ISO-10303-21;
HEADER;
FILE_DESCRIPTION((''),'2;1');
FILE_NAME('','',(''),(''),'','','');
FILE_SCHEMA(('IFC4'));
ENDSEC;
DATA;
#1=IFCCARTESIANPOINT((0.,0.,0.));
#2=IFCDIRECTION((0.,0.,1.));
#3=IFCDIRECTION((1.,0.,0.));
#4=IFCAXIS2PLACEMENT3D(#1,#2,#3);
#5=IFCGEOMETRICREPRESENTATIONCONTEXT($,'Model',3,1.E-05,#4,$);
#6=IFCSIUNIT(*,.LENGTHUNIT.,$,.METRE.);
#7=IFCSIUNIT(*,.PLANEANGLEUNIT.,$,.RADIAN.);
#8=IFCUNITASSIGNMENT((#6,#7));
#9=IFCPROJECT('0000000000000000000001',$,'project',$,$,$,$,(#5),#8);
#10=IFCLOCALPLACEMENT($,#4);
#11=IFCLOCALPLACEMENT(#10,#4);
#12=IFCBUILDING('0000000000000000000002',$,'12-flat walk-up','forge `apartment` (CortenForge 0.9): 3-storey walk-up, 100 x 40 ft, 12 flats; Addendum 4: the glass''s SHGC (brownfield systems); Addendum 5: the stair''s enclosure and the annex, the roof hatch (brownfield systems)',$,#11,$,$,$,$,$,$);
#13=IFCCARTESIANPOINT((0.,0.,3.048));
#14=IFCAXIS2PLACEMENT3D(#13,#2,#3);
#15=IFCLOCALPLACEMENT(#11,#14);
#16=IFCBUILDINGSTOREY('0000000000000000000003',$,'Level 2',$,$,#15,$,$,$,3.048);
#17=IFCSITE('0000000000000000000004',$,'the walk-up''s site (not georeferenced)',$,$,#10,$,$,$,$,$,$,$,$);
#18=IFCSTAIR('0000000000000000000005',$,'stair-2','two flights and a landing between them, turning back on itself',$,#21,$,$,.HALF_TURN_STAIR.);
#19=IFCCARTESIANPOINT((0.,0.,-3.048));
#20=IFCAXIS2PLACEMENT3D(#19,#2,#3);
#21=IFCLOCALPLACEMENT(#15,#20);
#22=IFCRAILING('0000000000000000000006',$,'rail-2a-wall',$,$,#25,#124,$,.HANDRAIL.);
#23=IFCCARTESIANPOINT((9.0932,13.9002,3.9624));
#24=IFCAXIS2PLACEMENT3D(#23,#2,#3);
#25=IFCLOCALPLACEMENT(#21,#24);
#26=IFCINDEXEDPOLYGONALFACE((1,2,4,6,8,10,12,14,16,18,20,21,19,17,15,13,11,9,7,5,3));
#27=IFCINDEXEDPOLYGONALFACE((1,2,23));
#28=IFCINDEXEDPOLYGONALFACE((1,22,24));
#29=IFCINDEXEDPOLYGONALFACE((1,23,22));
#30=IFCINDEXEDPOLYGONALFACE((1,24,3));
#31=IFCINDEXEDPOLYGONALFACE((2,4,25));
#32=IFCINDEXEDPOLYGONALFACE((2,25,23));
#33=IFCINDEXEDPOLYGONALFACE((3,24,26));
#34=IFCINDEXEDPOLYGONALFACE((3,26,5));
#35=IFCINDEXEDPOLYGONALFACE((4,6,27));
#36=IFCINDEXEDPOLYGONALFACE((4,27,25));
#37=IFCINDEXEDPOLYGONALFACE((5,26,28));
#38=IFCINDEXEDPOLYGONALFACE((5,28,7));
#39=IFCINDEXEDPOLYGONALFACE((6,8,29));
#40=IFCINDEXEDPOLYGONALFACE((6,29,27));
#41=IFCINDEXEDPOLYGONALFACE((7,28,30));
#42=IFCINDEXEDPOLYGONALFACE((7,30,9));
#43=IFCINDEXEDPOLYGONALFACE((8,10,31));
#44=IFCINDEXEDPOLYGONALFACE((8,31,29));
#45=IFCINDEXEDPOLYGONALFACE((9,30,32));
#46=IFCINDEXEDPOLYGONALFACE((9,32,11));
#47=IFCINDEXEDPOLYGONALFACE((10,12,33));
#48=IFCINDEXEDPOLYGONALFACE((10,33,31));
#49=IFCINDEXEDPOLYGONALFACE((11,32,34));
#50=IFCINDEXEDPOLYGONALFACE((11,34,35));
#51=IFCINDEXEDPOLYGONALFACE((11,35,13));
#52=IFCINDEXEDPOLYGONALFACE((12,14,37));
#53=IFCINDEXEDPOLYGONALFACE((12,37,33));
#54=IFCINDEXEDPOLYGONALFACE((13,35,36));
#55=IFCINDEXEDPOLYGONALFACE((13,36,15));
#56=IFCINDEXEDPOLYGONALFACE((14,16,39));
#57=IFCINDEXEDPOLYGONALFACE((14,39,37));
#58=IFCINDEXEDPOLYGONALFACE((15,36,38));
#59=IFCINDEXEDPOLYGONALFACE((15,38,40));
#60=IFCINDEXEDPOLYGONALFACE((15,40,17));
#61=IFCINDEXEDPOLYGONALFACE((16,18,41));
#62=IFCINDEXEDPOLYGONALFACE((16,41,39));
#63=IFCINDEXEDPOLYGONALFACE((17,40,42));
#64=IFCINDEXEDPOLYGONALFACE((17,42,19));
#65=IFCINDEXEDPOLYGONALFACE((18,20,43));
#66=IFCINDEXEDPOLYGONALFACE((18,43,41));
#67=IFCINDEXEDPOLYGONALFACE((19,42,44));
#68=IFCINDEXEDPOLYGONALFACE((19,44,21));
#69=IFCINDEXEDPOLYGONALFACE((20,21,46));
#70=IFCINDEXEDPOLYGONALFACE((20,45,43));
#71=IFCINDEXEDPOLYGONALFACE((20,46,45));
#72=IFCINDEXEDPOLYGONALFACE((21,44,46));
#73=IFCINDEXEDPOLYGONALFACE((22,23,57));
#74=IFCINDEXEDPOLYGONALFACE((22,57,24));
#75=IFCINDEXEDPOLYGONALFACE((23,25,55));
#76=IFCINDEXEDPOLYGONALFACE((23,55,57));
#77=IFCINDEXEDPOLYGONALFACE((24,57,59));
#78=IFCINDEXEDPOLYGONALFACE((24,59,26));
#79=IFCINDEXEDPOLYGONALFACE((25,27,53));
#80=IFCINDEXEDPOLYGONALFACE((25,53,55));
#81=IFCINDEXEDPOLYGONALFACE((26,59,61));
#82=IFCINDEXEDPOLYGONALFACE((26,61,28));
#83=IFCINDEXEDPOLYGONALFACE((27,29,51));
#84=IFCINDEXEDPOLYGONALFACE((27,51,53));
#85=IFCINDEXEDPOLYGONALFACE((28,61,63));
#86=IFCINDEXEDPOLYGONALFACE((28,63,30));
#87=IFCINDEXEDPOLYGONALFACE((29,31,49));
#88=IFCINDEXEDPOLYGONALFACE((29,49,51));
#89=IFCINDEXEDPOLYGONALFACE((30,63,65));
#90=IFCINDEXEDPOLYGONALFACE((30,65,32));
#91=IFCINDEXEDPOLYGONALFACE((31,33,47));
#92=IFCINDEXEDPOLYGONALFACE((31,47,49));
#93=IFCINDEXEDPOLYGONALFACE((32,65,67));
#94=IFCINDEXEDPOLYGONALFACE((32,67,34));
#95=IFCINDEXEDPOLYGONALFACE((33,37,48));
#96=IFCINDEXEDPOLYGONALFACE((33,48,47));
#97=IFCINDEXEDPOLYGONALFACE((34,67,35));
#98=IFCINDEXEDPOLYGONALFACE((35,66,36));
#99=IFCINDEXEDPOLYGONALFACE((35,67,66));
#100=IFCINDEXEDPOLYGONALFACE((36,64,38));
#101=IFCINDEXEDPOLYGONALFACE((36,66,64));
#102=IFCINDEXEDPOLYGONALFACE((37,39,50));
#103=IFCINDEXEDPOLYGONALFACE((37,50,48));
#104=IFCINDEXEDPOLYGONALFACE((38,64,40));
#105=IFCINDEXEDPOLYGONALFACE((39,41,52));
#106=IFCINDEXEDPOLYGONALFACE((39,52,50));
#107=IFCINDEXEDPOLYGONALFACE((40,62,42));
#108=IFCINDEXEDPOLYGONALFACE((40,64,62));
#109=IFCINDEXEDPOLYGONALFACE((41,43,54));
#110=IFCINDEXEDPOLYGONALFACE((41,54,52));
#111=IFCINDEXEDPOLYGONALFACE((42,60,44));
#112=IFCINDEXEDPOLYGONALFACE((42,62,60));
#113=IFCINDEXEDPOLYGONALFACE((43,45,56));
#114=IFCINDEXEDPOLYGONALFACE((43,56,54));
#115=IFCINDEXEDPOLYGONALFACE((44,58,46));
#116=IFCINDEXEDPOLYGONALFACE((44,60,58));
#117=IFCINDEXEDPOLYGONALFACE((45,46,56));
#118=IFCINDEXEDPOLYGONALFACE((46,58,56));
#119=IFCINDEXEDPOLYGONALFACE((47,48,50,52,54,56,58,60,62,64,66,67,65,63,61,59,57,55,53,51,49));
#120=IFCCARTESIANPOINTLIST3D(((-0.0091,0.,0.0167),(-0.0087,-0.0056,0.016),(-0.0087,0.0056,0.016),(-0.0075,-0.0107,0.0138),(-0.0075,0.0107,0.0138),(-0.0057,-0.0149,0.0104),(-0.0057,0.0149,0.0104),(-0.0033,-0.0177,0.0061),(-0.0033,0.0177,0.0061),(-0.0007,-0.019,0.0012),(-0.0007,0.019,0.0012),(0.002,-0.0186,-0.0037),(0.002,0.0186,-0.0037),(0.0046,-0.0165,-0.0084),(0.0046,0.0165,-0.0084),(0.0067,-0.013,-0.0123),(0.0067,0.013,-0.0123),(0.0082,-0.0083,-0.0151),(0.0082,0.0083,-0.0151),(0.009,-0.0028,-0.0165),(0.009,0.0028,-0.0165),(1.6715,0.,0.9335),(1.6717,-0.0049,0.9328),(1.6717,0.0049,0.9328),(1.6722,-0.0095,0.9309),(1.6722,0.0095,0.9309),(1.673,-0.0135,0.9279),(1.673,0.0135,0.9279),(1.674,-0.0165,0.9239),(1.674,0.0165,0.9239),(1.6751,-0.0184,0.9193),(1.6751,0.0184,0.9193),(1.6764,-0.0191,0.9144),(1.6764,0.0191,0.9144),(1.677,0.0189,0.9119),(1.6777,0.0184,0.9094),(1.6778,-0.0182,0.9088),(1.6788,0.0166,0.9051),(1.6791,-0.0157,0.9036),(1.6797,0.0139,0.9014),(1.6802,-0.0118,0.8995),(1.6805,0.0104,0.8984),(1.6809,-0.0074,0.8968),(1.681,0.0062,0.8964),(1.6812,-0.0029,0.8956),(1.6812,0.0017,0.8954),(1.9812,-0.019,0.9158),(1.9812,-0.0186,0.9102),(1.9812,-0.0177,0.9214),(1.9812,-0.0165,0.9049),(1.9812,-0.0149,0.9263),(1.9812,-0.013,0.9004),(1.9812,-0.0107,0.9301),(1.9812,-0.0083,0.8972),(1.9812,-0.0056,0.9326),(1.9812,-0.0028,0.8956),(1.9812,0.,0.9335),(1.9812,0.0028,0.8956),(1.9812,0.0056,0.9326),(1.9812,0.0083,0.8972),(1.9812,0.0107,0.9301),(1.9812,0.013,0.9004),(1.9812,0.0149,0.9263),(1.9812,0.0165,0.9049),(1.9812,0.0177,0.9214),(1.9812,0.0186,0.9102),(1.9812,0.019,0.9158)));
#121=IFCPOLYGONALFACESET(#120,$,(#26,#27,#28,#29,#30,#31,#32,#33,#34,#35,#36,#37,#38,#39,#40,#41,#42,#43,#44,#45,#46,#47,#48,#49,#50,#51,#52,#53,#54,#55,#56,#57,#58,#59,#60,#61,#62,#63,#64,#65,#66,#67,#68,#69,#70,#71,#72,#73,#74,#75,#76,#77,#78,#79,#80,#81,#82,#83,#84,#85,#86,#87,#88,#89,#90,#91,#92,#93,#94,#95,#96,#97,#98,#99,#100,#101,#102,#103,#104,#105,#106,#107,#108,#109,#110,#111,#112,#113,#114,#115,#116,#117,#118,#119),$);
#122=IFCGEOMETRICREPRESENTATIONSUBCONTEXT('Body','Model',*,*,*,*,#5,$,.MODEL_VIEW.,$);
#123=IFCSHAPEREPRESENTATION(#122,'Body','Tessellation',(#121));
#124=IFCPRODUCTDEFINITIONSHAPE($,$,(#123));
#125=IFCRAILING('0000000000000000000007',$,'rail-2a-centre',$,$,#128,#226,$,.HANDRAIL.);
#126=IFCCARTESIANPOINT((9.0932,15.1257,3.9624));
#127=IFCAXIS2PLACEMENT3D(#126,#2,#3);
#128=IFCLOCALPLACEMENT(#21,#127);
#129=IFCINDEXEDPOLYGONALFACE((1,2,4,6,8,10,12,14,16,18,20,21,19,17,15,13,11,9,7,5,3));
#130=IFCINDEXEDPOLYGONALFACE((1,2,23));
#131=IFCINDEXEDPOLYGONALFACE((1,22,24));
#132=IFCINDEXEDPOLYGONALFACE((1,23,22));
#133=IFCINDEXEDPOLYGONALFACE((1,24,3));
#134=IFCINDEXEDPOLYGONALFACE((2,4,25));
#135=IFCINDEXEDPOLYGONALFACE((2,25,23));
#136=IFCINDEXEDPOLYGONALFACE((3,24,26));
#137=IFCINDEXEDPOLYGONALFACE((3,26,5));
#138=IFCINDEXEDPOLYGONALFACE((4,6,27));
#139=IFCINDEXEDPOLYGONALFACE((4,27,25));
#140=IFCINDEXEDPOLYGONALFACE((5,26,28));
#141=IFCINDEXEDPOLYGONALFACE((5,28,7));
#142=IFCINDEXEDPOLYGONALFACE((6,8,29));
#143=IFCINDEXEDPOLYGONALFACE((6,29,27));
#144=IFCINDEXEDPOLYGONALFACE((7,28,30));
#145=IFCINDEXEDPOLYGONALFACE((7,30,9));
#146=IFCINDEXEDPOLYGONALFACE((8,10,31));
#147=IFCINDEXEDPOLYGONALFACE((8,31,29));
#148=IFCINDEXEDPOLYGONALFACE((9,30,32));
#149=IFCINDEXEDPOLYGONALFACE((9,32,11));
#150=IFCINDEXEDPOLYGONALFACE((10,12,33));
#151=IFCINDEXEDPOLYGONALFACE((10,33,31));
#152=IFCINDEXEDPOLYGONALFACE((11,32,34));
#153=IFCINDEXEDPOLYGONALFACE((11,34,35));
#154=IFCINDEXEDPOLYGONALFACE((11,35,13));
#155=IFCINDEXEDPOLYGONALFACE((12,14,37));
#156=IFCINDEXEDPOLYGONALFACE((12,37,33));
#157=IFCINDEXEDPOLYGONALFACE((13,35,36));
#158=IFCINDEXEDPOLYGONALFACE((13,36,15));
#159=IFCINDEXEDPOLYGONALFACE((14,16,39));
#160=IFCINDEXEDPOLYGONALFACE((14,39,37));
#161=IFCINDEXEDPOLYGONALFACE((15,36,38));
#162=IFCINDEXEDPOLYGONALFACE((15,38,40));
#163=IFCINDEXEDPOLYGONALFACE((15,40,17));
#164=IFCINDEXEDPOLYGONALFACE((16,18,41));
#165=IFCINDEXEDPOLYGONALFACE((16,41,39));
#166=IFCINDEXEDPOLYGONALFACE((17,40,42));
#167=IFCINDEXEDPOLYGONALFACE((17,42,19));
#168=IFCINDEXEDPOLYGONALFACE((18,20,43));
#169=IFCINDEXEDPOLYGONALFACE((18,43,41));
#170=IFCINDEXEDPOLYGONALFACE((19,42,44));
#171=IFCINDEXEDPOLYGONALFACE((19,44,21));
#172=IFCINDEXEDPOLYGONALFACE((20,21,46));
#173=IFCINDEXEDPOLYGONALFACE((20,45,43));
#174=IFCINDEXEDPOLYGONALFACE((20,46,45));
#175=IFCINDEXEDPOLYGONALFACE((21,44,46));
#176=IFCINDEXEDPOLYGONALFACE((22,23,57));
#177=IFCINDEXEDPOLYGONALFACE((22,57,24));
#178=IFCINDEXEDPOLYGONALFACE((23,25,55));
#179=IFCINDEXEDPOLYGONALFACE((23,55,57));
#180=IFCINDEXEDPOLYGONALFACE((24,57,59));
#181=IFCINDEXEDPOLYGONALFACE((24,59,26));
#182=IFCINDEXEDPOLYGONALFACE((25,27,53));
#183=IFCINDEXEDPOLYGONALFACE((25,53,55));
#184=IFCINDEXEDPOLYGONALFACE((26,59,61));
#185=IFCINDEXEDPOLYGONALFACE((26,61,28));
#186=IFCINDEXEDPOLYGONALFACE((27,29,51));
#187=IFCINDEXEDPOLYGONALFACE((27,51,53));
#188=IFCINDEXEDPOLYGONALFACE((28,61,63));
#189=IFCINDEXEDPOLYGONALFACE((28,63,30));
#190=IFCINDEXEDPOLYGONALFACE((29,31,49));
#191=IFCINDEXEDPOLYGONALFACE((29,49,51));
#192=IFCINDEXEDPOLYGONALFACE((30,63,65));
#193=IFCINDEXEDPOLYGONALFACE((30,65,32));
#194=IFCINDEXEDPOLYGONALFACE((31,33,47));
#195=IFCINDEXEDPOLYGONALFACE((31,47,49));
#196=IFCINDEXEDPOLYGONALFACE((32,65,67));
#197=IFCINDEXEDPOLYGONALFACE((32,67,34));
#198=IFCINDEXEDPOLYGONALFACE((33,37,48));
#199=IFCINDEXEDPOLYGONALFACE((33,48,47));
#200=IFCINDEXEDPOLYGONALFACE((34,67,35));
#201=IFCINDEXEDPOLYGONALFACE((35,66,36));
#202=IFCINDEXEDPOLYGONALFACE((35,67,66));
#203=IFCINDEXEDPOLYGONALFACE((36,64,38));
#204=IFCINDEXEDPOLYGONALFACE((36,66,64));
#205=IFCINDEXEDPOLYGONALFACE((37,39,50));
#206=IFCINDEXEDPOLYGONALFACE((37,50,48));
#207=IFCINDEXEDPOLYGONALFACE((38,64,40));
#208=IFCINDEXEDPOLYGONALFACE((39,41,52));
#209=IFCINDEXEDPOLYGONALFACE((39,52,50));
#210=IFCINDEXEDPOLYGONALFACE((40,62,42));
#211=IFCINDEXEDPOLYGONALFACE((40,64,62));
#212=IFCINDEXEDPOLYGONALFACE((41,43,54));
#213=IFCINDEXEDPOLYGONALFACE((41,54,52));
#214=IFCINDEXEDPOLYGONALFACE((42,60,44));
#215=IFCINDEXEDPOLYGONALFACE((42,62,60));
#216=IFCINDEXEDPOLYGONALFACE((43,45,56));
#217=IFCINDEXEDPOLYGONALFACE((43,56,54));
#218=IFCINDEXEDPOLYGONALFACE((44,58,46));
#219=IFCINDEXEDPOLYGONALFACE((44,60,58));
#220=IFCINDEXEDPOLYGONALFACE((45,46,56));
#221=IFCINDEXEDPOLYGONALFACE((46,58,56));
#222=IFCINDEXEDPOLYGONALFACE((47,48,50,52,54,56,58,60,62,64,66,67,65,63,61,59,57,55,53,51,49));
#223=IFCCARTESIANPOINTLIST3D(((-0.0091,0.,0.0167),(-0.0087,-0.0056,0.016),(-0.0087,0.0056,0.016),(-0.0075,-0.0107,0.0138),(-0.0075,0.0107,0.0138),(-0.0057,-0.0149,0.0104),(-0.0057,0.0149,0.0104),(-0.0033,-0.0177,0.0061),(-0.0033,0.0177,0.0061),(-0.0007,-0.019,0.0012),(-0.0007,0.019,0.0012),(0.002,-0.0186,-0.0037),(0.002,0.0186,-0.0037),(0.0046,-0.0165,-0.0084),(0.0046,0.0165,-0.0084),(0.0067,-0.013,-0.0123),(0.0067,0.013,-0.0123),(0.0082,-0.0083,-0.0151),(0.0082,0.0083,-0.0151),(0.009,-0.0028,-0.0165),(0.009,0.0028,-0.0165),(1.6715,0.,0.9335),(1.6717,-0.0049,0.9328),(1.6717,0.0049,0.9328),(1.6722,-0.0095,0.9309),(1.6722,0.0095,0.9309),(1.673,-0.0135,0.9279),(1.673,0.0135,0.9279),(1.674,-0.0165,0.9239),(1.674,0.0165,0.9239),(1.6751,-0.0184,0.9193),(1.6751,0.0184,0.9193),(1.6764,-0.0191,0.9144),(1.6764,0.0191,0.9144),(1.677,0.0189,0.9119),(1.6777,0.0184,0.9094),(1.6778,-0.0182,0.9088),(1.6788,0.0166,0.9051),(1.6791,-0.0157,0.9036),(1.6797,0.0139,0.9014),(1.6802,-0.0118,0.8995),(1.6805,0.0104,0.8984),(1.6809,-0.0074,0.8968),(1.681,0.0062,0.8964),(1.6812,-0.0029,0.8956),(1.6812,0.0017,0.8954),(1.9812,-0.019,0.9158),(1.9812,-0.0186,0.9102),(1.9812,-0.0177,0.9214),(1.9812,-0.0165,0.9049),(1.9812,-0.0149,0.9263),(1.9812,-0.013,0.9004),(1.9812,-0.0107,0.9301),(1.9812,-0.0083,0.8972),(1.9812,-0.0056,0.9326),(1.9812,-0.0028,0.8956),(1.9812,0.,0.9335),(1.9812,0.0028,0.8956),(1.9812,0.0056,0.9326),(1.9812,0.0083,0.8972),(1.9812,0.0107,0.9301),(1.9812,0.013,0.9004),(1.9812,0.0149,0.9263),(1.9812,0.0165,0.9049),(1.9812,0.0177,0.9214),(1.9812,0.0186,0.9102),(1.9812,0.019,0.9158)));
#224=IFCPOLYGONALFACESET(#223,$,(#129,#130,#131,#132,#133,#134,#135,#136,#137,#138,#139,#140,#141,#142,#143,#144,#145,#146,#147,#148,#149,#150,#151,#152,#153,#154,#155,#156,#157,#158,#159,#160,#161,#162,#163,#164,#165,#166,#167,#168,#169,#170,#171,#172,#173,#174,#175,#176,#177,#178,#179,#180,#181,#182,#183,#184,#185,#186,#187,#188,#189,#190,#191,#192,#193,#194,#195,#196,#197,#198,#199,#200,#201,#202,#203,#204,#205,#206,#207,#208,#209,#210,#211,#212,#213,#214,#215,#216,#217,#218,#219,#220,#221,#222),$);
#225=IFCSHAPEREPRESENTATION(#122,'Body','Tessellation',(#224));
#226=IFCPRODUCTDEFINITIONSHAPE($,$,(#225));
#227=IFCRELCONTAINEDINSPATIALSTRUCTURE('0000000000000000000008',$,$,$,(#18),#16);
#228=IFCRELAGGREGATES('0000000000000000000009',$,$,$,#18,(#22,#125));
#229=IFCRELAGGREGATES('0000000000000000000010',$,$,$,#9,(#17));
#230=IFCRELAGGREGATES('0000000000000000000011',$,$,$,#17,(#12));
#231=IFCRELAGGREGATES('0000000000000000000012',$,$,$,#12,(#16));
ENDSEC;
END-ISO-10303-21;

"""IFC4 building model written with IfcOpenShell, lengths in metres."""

from ifc_helpers import new_model, entity, si_unit, frame, origin_with_axes, place, context, subcontext, project, spatial, element, aggregate, save


model = new_model("IFC4")

# Units and contexts
model_context = context("Model", 3, precision=1e-05, world=origin_with_axes())
body_context = subcontext(model_context, "Body", "Model", "MODEL_VIEW")
ifc_project = project(units=[si_unit("LENGTHUNIT", "METRE"), si_unit("PLANEANGLEUNIT", "RADIAN")], contexts=[model_context])

# Site, building, storey
site_placement = place(None, origin_with_axes())
site = spatial("IfcSite", under=ifc_project, at=site_placement, Name="the walk-up's site (not georeferenced)")
building_placement = place(site_placement, origin_with_axes())
building = spatial("IfcBuilding", under=site, at=building_placement, Name="12-flat walk-up", Description="forge `apartment` (CortenForge 0.9): 3-storey walk-up, 100 x 40 ft, 12 flats; Addendum 4: the glass's SHGC (brownfield systems); Addendum 5: the stair's enclosure and the annex, the roof hatch (brownfield systems)")
storey_placement = place(building_placement, frame((0.0, 0.0, 3.048), z_axis=(0.0, 0.0, 1.0), x_axis=(1.0, 0.0, 0.0)))
storey = spatial("IfcBuildingStorey", under=building, at=storey_placement, Name="Level 2", Elevation=3.048)

# Stair, railings
stair_placement = place(storey_placement, frame((0.0, 0.0, -3.048), z_axis=(0.0, 0.0, 1.0), x_axis=(1.0, 0.0, 0.0)))
stair = element("IfcStair", 1, at=stair_placement, inside=storey, Name="stair-2", Description="two flights and a landing between them, turning back on itself", PredefinedType="HALF_TURN_STAIR")
railing_1_placement = place(stair_placement, frame((9.0932, 13.9002, 3.9624), z_axis=(0.0, 0.0, 1.0), x_axis=(1.0, 0.0, 0.0)))
railing_1 = element("IfcRailing", 2, at=railing_1_placement, Name="rail-2a-wall", PredefinedType="HANDRAIL", context=body_context, shape_type="AdvancedSweptSolid", body=[
    entity("IfcSweptDiskSolid", entity("IfcPolyline", [entity("IfcCartesianPoint", [0.0, 0.0, 0.0]), entity("IfcCartesianPoint", [1.6764, 0.0, 0.9144]), entity("IfcCartesianPoint", [1.9812, 0.0, 0.9144])]), 0.0191),
])
railing_2_placement = place(stair_placement, frame((9.0932, 15.1257, 3.9624), z_axis=(0.0, 0.0, 1.0), x_axis=(1.0, 0.0, 0.0)))
railing_2 = element("IfcRailing", 3, at=railing_2_placement, Name="rail-2a-centre", PredefinedType="HANDRAIL", context=body_context, shape_type="AdvancedSweptSolid", body=[
    entity("IfcSweptDiskSolid", entity("IfcPolyline", [entity("IfcCartesianPoint", [0.0, 0.0, 0.0]), entity("IfcCartesianPoint", [1.6764, 0.0, 0.9144]), entity("IfcCartesianPoint", [1.9812, 0.0, 0.9144])]), 0.0191),
])
aggregate(stair, [railing_1, railing_2])

save(model, "model.ifc")
